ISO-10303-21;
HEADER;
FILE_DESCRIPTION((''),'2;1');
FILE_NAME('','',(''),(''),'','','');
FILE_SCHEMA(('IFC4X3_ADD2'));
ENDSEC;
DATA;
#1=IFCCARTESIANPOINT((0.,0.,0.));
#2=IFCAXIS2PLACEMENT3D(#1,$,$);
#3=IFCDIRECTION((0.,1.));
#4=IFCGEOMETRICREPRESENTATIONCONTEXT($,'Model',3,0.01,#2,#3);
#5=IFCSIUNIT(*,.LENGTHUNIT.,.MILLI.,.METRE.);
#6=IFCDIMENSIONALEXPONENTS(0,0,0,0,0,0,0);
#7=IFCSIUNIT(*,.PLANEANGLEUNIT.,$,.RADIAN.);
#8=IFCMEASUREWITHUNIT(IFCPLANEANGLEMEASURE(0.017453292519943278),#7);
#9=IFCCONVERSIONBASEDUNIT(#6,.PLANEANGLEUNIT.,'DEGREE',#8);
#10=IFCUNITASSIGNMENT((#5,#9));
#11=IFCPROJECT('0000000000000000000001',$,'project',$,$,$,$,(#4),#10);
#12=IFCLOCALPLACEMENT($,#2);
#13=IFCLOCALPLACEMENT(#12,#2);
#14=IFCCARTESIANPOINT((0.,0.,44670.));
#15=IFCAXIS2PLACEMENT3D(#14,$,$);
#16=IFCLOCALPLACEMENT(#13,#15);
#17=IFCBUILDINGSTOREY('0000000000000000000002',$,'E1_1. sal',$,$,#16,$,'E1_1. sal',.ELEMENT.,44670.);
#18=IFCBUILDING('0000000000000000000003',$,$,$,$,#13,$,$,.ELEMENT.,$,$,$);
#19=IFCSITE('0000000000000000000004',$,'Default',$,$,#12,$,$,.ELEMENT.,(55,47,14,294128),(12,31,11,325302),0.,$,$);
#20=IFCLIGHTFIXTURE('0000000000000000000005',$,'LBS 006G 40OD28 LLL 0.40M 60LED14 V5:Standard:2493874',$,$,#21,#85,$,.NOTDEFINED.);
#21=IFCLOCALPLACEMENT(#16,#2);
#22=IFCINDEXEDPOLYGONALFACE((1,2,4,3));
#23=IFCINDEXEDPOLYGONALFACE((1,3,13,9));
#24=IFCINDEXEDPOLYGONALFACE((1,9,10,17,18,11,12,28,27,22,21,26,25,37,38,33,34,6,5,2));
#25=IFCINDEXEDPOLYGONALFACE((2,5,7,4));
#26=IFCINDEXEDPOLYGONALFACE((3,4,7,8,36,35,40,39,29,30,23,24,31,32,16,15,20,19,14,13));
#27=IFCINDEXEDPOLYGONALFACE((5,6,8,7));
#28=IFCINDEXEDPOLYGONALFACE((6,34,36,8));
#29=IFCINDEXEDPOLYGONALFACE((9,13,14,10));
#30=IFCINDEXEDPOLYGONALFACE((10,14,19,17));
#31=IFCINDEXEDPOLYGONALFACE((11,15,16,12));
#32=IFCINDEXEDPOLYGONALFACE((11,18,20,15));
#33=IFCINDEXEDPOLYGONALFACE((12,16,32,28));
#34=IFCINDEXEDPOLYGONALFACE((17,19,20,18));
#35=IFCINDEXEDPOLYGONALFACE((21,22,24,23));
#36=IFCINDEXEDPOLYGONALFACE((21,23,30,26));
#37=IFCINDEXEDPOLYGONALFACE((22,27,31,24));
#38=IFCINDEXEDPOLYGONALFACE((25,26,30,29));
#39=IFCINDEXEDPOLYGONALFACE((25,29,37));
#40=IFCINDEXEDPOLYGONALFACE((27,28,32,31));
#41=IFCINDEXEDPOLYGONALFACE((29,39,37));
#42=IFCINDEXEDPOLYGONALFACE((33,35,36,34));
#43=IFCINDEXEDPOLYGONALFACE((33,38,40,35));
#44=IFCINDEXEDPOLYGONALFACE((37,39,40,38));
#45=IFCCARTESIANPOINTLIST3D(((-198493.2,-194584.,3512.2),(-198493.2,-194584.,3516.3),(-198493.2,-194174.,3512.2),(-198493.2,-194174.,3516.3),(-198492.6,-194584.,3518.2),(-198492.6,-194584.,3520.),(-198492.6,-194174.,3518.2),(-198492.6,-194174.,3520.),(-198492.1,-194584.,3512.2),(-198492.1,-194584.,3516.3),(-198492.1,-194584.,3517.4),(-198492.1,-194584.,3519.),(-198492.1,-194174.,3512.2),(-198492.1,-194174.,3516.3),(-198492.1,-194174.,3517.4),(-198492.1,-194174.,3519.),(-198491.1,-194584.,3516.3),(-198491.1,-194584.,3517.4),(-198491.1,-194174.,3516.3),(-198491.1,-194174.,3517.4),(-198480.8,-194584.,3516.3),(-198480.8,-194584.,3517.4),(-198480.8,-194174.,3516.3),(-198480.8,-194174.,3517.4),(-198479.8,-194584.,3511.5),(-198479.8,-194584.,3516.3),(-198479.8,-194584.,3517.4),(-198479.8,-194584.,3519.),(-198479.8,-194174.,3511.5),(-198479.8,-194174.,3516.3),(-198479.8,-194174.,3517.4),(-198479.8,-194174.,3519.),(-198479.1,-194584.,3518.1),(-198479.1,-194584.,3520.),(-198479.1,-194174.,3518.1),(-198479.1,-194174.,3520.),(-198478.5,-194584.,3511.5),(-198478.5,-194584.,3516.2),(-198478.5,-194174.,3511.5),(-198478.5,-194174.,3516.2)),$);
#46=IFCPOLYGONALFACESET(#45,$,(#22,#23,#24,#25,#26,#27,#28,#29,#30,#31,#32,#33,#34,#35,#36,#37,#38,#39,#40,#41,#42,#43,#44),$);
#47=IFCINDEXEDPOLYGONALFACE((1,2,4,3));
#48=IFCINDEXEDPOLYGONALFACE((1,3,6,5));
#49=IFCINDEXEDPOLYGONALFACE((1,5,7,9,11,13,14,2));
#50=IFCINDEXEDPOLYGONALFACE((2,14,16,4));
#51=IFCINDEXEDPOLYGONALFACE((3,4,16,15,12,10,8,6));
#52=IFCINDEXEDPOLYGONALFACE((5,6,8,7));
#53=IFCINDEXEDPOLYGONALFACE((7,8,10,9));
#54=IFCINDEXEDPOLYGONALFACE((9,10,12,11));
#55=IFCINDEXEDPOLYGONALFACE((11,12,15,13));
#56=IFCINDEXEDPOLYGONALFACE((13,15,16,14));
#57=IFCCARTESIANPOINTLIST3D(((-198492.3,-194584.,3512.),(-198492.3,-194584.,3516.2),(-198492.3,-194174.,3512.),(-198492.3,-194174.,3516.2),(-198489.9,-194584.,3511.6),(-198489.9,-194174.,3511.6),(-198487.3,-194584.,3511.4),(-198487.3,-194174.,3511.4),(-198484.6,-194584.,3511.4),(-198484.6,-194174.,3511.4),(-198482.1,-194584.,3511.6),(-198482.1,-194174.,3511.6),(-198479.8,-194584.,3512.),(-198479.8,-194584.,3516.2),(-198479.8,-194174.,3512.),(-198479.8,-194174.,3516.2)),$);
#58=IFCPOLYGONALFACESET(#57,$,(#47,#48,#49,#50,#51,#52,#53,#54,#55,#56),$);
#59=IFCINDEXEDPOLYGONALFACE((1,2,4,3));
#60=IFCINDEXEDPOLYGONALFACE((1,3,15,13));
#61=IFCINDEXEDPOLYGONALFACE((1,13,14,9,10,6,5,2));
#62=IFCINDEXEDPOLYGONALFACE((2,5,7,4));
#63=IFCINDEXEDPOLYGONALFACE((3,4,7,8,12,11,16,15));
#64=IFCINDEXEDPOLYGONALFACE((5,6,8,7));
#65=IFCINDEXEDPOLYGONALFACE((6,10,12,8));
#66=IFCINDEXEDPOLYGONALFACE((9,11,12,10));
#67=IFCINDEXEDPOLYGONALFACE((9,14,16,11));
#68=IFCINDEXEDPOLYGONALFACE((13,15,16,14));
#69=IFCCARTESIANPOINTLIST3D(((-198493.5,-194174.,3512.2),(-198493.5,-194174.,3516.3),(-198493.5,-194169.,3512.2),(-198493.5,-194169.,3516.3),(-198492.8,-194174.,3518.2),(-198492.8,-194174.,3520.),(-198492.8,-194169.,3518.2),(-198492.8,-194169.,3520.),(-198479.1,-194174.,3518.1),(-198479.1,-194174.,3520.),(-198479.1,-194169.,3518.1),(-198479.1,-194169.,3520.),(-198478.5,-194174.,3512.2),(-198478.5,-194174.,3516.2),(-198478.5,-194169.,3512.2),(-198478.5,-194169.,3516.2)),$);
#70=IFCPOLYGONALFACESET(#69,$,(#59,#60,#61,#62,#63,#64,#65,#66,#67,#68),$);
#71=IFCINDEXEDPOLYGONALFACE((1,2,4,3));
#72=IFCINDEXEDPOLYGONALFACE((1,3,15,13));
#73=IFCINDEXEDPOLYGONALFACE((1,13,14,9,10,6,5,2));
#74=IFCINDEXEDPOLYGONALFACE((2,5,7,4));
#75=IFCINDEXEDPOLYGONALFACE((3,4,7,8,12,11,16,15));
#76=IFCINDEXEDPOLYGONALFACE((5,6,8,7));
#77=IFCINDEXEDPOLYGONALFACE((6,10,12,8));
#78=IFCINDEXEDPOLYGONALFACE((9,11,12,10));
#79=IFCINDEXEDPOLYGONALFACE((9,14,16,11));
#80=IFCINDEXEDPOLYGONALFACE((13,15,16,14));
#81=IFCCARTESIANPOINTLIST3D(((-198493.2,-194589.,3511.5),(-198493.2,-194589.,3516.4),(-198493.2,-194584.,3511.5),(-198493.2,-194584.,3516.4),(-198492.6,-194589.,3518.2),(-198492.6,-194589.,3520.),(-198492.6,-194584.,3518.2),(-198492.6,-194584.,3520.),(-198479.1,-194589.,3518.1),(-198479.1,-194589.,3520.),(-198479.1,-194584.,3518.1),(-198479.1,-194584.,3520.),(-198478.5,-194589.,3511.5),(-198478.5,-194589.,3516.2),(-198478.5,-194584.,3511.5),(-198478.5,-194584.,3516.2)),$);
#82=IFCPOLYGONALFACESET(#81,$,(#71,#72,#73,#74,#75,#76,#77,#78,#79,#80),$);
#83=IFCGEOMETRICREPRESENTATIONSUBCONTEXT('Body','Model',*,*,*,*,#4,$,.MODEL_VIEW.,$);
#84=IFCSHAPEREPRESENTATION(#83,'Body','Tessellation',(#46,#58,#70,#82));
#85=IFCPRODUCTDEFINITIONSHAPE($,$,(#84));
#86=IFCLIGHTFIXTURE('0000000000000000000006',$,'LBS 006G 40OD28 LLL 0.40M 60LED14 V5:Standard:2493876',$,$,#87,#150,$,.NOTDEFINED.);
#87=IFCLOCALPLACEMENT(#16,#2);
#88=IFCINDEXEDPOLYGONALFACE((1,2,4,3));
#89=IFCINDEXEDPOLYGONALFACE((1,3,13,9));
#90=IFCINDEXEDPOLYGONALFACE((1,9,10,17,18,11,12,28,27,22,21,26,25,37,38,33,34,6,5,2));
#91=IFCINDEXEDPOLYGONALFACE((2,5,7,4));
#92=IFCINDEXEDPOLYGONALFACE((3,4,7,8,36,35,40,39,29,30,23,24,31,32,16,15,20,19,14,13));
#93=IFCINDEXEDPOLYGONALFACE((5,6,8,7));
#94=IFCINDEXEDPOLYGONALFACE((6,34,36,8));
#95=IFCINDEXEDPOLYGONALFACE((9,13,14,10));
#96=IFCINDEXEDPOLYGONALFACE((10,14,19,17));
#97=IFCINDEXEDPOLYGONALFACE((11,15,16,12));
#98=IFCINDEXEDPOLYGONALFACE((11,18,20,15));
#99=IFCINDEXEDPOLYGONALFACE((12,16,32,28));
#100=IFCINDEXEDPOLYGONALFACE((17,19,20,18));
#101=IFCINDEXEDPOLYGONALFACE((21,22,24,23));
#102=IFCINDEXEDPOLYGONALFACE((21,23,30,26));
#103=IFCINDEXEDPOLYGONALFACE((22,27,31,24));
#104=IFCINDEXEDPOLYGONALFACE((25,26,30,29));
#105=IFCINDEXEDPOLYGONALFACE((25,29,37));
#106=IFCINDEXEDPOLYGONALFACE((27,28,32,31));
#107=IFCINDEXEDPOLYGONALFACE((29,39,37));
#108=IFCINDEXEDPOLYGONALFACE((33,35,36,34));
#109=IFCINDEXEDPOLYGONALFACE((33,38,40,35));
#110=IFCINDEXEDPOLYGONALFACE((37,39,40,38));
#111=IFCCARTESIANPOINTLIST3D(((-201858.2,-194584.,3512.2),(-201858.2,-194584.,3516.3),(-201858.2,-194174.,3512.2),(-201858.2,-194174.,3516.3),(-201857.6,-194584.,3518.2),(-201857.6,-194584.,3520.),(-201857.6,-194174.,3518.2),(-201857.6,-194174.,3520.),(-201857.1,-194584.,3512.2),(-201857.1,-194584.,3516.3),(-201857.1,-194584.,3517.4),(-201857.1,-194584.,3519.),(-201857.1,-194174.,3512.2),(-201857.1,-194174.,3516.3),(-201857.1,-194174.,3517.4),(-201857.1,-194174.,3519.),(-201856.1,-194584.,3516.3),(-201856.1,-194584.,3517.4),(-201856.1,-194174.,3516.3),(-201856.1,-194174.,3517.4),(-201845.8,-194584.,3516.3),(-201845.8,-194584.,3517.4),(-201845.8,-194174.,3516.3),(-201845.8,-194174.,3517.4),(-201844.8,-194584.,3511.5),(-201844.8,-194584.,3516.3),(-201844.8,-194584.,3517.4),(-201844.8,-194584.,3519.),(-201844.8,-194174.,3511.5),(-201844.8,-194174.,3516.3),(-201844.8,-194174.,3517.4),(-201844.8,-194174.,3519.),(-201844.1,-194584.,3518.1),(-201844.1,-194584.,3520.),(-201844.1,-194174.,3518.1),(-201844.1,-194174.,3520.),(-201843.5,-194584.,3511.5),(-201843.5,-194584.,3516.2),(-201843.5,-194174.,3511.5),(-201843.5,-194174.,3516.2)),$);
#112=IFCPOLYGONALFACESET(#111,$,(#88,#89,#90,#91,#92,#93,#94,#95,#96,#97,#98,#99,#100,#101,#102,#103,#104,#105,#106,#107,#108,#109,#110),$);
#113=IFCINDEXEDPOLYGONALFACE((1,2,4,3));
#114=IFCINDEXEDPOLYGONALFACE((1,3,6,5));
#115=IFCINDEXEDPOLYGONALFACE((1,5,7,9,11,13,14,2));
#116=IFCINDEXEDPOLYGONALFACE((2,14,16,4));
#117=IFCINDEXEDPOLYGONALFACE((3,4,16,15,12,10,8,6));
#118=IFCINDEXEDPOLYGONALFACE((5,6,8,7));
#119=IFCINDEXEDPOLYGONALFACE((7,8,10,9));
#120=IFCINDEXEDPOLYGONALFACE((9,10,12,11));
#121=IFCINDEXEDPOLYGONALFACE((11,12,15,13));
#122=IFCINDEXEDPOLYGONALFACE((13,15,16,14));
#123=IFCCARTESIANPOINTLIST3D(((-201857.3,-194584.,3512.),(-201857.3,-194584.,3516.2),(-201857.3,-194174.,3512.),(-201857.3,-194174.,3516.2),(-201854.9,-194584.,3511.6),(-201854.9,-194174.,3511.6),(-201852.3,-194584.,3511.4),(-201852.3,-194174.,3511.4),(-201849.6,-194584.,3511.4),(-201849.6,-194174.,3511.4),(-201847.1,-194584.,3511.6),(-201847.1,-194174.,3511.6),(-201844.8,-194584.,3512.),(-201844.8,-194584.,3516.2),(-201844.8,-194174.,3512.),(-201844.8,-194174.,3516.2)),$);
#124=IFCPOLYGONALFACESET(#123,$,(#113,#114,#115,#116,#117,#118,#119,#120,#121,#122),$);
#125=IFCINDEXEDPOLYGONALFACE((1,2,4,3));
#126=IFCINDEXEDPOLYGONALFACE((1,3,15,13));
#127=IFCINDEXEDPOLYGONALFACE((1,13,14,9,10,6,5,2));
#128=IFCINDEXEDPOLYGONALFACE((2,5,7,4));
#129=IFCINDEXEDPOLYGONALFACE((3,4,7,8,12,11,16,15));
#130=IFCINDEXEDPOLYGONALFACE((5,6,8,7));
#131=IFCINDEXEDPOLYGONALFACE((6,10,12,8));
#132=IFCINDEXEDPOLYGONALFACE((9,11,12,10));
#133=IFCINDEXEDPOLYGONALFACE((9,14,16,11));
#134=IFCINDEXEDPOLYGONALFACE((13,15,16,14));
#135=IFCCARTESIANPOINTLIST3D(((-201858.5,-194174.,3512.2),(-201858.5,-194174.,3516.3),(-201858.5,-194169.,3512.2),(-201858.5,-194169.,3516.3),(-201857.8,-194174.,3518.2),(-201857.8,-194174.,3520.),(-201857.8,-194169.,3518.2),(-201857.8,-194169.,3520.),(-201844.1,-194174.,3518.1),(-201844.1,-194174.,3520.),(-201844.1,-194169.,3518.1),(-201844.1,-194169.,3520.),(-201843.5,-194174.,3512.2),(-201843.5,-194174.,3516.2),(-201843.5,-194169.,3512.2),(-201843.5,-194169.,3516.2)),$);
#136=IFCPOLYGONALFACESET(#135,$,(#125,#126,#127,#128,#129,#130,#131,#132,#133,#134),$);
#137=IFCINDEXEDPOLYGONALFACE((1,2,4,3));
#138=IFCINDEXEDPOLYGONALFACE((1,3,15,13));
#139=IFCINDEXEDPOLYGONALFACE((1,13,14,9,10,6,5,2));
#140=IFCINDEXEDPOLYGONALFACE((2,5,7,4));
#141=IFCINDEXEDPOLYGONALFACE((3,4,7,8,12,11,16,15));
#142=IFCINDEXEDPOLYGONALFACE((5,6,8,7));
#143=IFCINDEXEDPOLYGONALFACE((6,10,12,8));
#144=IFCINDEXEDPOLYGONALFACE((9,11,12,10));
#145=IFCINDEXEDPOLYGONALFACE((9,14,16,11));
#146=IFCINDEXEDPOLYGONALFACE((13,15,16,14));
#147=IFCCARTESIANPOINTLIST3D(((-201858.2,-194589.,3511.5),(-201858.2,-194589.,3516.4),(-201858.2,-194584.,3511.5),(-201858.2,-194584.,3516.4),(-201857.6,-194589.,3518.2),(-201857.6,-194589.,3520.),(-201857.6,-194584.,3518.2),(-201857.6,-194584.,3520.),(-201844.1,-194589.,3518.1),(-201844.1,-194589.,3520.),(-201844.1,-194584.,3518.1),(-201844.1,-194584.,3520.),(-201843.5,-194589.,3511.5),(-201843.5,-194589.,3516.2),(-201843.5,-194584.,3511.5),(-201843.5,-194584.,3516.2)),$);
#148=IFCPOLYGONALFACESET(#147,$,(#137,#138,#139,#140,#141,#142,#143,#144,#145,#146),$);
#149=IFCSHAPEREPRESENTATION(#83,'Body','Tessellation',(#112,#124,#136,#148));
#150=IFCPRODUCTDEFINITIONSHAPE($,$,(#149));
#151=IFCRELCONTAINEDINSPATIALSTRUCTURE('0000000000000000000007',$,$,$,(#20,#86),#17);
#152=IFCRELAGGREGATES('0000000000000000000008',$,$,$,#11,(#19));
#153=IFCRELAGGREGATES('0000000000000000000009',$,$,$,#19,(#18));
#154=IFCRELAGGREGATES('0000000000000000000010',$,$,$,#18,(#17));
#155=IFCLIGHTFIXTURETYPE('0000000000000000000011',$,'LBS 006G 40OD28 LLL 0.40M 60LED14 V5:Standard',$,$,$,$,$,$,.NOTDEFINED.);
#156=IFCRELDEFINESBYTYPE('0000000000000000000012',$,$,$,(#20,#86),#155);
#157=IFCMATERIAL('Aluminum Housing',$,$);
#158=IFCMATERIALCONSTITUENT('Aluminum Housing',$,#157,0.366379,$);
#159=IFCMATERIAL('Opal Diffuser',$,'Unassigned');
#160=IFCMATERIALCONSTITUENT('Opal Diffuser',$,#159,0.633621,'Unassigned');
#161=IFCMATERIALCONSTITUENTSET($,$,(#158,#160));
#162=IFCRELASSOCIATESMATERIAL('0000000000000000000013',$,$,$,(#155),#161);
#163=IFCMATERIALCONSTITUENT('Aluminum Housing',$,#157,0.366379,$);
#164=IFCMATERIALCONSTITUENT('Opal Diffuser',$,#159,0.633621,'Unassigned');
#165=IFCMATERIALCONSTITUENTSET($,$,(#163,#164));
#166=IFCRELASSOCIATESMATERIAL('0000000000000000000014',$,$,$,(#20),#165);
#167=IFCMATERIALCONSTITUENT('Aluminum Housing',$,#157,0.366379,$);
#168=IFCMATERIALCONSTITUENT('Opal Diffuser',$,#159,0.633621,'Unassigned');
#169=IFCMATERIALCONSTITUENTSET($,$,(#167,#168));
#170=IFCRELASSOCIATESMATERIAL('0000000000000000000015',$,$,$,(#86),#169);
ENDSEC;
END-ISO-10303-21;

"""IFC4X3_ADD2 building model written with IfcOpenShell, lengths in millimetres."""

from ifc_helpers import new_model, entity, si_unit, converted_unit, direction, frame, origin, place, context, subcontext, project, spatial, polyline, outline, extrude, source, transform, mapped, material, constituent, constituent_set, type_object, type_shapes, element, save


model = new_model("IFC4X3_ADD2")

# Units and contexts
model_context = context("Model", 3, precision=0.01, world=origin(), true_north=direction((0.0, 1.0)))
body_context = subcontext(model_context, "Body", "Model", "MODEL_VIEW")
ifc_project = project(units=[si_unit("LENGTHUNIT", "METRE", prefix="MILLI"), converted_unit("PLANEANGLEUNIT", "DEGREE", entity("IfcPlaneAngleMeasure", 0.017453292519943278), si_unit("PLANEANGLEUNIT", "RADIAN"), dimensions=[0, 0, 0, 0, 0, 0, 0])], contexts=[model_context])

# Site, building, storey
site_placement = place(None, origin())
site = spatial("IfcSite", under=ifc_project, at=site_placement, Name="Default", CompositionType="ELEMENT", RefLatitude=(55, 47, 14, 294128), RefLongitude=(12, 31, 11, 325302), RefElevation=0.0)
building_placement = place(site_placement, origin())
building = spatial("IfcBuilding", under=site, at=building_placement, CompositionType="ELEMENT")
storey_placement = place(building_placement, frame((0.0, 0.0, 44670.0)))
storey = spatial("IfcBuildingStorey", under=building, at=storey_placement, Name="E1_1. sal", LongName="E1_1. sal", CompositionType="ELEMENT", Elevation=44670.0)

# Light fixtures
ifc_material_1 = material(Name="Aluminum Housing")
ifc_material_2 = material(Name="Opal Diffuser", Category="Unassigned")
ifc_constituent_1 = constituent(ifc_material_1, Name="Aluminum Housing", fraction=0.366379)
ifc_constituent_2 = constituent(ifc_material_2, Name="Opal Diffuser", Category="Unassigned", fraction=0.633621)
ifc_constituent_set_1 = constituent_set(constituents=[ifc_constituent_1, ifc_constituent_2])
light_fixture_type = type_object("IfcLightFixtureType", Name="LBS 006G 40OD28 LLL 0.40M 60LED14 V5:Standard", PredefinedType="NOTDEFINED", material=ifc_constituent_set_1)
shared_shape_1 = source(origin(), body_context, "Body", "SweptSolid", [
    extrude(outline(polyline([(-5.0, -6.1), (-5.0, -7.4), (-0.3, -7.4), (1.7, -6.8), (3.5, -6.8), (3.5, 6.7), (1.8, 6.7), (-0.1, 7.3), (-4.2, 7.3), (-4.2, 6.2), (-0.1, 6.2), (-0.1, 5.2), (0.9, 5.2), (0.9, 6.2), (2.5, 6.2), (2.5, -6.1), (0.9, -6.1), (0.9, -5.1), (-0.1, -5.1), (-0.1, -6.1), (-5.0, -6.1)])), frame((-205.0, 0.1, 3.5), z_axis=(-1.0, 0.0, 0.0), x_axis=(0.0, 0.0, -1.0)), (0.0, 0.0, -1.0), 410.0),
    extrude(outline(polyline([(-0.8, -6.2), (3.4, -6.2), (3.4, 6.2), (-0.8, 6.2), (-1.2, 3.9), (-1.4, 1.4), (-1.4, -1.3), (-1.2, -3.9), (-0.8, -6.2)])), frame((-205.0, 0.0, 7.2), z_axis=(1.0, 0.0, 0.0), x_axis=(0.0, 0.0, -1.0)), (0.0, 0.0, 1.0), 410.0),
    extrude(outline(polyline([(-4.4, -7.5), (-0.3, -7.5), (1.5, -6.8), (3.3, -6.8), (3.3, 6.9), (1.5, 6.9), (-0.5, 7.4), (-4.4, 7.4), (-4.4, -7.5)])), frame((205.0, 0.0, 3.3), z_axis=(1.0, 0.0, 0.0), x_axis=(0.0, 0.0, -1.0)), (0.0, 0.0, 1.0), 5.0),
    extrude(outline(polyline([(-5.0, -7.4), (-0.1, -7.4), (1.7, -6.7), (3.5, -6.7), (3.5, 6.8), (1.6, 6.8), (-0.3, 7.3), (-5.0, 7.3), (-5.0, -7.4)])), frame((-210.0, 0.2, 3.5), z_axis=(1.0, 0.0, 0.0), x_axis=(0.0, 0.0, -1.0)), (0.0, 0.0, 1.0), 5.0),
])
type_shapes(light_fixture_type, [shared_shape_1])
ifc_constituent_3 = constituent(ifc_material_1, Name="Aluminum Housing", fraction=0.366379)
ifc_constituent_4 = constituent(ifc_material_2, Name="Opal Diffuser", Category="Unassigned", fraction=0.633621)
ifc_constituent_set_2 = constituent_set(constituents=[ifc_constituent_3, ifc_constituent_4])
light_fixture_1_placement = place(storey_placement, frame((-198486.0, -194379.0, 3520.0), z_axis=(0.0, 0.0, -1.0), x_axis=(0.0, 1.0, 0.0)))
element("IfcLightFixture", 1, at=light_fixture_1_placement, inside=storey, type_object=light_fixture_type, material=ifc_constituent_set_2, Name="LBS 006G 40OD28 LLL 0.40M 60LED14 V5:Standard:2493874", PredefinedType="NOTDEFINED", context=body_context, shape_type="MappedRepresentation", body=[
    mapped(shared_shape_1, transform((0.0, 0.0, 0.0), scale=1.0)),
])
ifc_constituent_5 = constituent(ifc_material_1, Name="Aluminum Housing", fraction=0.366379)
ifc_constituent_6 = constituent(ifc_material_2, Name="Opal Diffuser", Category="Unassigned", fraction=0.633621)
ifc_constituent_set_3 = constituent_set(constituents=[ifc_constituent_5, ifc_constituent_6])
light_fixture_2_placement = place(storey_placement, frame((-201851.0, -194379.0, 3520.0), z_axis=(0.0, 0.0, -1.0), x_axis=(0.0, 1.0, 0.0)))
element("IfcLightFixture", 2, at=light_fixture_2_placement, inside=storey, type_object=light_fixture_type, material=ifc_constituent_set_3, Name="LBS 006G 40OD28 LLL 0.40M 60LED14 V5:Standard:2493876", PredefinedType="NOTDEFINED", context=body_context, shape_type="MappedRepresentation", body=[
    mapped(shared_shape_1, transform((0.0, 0.0, 0.0), scale=1.0)),
])

save(model, "model.ifc")
